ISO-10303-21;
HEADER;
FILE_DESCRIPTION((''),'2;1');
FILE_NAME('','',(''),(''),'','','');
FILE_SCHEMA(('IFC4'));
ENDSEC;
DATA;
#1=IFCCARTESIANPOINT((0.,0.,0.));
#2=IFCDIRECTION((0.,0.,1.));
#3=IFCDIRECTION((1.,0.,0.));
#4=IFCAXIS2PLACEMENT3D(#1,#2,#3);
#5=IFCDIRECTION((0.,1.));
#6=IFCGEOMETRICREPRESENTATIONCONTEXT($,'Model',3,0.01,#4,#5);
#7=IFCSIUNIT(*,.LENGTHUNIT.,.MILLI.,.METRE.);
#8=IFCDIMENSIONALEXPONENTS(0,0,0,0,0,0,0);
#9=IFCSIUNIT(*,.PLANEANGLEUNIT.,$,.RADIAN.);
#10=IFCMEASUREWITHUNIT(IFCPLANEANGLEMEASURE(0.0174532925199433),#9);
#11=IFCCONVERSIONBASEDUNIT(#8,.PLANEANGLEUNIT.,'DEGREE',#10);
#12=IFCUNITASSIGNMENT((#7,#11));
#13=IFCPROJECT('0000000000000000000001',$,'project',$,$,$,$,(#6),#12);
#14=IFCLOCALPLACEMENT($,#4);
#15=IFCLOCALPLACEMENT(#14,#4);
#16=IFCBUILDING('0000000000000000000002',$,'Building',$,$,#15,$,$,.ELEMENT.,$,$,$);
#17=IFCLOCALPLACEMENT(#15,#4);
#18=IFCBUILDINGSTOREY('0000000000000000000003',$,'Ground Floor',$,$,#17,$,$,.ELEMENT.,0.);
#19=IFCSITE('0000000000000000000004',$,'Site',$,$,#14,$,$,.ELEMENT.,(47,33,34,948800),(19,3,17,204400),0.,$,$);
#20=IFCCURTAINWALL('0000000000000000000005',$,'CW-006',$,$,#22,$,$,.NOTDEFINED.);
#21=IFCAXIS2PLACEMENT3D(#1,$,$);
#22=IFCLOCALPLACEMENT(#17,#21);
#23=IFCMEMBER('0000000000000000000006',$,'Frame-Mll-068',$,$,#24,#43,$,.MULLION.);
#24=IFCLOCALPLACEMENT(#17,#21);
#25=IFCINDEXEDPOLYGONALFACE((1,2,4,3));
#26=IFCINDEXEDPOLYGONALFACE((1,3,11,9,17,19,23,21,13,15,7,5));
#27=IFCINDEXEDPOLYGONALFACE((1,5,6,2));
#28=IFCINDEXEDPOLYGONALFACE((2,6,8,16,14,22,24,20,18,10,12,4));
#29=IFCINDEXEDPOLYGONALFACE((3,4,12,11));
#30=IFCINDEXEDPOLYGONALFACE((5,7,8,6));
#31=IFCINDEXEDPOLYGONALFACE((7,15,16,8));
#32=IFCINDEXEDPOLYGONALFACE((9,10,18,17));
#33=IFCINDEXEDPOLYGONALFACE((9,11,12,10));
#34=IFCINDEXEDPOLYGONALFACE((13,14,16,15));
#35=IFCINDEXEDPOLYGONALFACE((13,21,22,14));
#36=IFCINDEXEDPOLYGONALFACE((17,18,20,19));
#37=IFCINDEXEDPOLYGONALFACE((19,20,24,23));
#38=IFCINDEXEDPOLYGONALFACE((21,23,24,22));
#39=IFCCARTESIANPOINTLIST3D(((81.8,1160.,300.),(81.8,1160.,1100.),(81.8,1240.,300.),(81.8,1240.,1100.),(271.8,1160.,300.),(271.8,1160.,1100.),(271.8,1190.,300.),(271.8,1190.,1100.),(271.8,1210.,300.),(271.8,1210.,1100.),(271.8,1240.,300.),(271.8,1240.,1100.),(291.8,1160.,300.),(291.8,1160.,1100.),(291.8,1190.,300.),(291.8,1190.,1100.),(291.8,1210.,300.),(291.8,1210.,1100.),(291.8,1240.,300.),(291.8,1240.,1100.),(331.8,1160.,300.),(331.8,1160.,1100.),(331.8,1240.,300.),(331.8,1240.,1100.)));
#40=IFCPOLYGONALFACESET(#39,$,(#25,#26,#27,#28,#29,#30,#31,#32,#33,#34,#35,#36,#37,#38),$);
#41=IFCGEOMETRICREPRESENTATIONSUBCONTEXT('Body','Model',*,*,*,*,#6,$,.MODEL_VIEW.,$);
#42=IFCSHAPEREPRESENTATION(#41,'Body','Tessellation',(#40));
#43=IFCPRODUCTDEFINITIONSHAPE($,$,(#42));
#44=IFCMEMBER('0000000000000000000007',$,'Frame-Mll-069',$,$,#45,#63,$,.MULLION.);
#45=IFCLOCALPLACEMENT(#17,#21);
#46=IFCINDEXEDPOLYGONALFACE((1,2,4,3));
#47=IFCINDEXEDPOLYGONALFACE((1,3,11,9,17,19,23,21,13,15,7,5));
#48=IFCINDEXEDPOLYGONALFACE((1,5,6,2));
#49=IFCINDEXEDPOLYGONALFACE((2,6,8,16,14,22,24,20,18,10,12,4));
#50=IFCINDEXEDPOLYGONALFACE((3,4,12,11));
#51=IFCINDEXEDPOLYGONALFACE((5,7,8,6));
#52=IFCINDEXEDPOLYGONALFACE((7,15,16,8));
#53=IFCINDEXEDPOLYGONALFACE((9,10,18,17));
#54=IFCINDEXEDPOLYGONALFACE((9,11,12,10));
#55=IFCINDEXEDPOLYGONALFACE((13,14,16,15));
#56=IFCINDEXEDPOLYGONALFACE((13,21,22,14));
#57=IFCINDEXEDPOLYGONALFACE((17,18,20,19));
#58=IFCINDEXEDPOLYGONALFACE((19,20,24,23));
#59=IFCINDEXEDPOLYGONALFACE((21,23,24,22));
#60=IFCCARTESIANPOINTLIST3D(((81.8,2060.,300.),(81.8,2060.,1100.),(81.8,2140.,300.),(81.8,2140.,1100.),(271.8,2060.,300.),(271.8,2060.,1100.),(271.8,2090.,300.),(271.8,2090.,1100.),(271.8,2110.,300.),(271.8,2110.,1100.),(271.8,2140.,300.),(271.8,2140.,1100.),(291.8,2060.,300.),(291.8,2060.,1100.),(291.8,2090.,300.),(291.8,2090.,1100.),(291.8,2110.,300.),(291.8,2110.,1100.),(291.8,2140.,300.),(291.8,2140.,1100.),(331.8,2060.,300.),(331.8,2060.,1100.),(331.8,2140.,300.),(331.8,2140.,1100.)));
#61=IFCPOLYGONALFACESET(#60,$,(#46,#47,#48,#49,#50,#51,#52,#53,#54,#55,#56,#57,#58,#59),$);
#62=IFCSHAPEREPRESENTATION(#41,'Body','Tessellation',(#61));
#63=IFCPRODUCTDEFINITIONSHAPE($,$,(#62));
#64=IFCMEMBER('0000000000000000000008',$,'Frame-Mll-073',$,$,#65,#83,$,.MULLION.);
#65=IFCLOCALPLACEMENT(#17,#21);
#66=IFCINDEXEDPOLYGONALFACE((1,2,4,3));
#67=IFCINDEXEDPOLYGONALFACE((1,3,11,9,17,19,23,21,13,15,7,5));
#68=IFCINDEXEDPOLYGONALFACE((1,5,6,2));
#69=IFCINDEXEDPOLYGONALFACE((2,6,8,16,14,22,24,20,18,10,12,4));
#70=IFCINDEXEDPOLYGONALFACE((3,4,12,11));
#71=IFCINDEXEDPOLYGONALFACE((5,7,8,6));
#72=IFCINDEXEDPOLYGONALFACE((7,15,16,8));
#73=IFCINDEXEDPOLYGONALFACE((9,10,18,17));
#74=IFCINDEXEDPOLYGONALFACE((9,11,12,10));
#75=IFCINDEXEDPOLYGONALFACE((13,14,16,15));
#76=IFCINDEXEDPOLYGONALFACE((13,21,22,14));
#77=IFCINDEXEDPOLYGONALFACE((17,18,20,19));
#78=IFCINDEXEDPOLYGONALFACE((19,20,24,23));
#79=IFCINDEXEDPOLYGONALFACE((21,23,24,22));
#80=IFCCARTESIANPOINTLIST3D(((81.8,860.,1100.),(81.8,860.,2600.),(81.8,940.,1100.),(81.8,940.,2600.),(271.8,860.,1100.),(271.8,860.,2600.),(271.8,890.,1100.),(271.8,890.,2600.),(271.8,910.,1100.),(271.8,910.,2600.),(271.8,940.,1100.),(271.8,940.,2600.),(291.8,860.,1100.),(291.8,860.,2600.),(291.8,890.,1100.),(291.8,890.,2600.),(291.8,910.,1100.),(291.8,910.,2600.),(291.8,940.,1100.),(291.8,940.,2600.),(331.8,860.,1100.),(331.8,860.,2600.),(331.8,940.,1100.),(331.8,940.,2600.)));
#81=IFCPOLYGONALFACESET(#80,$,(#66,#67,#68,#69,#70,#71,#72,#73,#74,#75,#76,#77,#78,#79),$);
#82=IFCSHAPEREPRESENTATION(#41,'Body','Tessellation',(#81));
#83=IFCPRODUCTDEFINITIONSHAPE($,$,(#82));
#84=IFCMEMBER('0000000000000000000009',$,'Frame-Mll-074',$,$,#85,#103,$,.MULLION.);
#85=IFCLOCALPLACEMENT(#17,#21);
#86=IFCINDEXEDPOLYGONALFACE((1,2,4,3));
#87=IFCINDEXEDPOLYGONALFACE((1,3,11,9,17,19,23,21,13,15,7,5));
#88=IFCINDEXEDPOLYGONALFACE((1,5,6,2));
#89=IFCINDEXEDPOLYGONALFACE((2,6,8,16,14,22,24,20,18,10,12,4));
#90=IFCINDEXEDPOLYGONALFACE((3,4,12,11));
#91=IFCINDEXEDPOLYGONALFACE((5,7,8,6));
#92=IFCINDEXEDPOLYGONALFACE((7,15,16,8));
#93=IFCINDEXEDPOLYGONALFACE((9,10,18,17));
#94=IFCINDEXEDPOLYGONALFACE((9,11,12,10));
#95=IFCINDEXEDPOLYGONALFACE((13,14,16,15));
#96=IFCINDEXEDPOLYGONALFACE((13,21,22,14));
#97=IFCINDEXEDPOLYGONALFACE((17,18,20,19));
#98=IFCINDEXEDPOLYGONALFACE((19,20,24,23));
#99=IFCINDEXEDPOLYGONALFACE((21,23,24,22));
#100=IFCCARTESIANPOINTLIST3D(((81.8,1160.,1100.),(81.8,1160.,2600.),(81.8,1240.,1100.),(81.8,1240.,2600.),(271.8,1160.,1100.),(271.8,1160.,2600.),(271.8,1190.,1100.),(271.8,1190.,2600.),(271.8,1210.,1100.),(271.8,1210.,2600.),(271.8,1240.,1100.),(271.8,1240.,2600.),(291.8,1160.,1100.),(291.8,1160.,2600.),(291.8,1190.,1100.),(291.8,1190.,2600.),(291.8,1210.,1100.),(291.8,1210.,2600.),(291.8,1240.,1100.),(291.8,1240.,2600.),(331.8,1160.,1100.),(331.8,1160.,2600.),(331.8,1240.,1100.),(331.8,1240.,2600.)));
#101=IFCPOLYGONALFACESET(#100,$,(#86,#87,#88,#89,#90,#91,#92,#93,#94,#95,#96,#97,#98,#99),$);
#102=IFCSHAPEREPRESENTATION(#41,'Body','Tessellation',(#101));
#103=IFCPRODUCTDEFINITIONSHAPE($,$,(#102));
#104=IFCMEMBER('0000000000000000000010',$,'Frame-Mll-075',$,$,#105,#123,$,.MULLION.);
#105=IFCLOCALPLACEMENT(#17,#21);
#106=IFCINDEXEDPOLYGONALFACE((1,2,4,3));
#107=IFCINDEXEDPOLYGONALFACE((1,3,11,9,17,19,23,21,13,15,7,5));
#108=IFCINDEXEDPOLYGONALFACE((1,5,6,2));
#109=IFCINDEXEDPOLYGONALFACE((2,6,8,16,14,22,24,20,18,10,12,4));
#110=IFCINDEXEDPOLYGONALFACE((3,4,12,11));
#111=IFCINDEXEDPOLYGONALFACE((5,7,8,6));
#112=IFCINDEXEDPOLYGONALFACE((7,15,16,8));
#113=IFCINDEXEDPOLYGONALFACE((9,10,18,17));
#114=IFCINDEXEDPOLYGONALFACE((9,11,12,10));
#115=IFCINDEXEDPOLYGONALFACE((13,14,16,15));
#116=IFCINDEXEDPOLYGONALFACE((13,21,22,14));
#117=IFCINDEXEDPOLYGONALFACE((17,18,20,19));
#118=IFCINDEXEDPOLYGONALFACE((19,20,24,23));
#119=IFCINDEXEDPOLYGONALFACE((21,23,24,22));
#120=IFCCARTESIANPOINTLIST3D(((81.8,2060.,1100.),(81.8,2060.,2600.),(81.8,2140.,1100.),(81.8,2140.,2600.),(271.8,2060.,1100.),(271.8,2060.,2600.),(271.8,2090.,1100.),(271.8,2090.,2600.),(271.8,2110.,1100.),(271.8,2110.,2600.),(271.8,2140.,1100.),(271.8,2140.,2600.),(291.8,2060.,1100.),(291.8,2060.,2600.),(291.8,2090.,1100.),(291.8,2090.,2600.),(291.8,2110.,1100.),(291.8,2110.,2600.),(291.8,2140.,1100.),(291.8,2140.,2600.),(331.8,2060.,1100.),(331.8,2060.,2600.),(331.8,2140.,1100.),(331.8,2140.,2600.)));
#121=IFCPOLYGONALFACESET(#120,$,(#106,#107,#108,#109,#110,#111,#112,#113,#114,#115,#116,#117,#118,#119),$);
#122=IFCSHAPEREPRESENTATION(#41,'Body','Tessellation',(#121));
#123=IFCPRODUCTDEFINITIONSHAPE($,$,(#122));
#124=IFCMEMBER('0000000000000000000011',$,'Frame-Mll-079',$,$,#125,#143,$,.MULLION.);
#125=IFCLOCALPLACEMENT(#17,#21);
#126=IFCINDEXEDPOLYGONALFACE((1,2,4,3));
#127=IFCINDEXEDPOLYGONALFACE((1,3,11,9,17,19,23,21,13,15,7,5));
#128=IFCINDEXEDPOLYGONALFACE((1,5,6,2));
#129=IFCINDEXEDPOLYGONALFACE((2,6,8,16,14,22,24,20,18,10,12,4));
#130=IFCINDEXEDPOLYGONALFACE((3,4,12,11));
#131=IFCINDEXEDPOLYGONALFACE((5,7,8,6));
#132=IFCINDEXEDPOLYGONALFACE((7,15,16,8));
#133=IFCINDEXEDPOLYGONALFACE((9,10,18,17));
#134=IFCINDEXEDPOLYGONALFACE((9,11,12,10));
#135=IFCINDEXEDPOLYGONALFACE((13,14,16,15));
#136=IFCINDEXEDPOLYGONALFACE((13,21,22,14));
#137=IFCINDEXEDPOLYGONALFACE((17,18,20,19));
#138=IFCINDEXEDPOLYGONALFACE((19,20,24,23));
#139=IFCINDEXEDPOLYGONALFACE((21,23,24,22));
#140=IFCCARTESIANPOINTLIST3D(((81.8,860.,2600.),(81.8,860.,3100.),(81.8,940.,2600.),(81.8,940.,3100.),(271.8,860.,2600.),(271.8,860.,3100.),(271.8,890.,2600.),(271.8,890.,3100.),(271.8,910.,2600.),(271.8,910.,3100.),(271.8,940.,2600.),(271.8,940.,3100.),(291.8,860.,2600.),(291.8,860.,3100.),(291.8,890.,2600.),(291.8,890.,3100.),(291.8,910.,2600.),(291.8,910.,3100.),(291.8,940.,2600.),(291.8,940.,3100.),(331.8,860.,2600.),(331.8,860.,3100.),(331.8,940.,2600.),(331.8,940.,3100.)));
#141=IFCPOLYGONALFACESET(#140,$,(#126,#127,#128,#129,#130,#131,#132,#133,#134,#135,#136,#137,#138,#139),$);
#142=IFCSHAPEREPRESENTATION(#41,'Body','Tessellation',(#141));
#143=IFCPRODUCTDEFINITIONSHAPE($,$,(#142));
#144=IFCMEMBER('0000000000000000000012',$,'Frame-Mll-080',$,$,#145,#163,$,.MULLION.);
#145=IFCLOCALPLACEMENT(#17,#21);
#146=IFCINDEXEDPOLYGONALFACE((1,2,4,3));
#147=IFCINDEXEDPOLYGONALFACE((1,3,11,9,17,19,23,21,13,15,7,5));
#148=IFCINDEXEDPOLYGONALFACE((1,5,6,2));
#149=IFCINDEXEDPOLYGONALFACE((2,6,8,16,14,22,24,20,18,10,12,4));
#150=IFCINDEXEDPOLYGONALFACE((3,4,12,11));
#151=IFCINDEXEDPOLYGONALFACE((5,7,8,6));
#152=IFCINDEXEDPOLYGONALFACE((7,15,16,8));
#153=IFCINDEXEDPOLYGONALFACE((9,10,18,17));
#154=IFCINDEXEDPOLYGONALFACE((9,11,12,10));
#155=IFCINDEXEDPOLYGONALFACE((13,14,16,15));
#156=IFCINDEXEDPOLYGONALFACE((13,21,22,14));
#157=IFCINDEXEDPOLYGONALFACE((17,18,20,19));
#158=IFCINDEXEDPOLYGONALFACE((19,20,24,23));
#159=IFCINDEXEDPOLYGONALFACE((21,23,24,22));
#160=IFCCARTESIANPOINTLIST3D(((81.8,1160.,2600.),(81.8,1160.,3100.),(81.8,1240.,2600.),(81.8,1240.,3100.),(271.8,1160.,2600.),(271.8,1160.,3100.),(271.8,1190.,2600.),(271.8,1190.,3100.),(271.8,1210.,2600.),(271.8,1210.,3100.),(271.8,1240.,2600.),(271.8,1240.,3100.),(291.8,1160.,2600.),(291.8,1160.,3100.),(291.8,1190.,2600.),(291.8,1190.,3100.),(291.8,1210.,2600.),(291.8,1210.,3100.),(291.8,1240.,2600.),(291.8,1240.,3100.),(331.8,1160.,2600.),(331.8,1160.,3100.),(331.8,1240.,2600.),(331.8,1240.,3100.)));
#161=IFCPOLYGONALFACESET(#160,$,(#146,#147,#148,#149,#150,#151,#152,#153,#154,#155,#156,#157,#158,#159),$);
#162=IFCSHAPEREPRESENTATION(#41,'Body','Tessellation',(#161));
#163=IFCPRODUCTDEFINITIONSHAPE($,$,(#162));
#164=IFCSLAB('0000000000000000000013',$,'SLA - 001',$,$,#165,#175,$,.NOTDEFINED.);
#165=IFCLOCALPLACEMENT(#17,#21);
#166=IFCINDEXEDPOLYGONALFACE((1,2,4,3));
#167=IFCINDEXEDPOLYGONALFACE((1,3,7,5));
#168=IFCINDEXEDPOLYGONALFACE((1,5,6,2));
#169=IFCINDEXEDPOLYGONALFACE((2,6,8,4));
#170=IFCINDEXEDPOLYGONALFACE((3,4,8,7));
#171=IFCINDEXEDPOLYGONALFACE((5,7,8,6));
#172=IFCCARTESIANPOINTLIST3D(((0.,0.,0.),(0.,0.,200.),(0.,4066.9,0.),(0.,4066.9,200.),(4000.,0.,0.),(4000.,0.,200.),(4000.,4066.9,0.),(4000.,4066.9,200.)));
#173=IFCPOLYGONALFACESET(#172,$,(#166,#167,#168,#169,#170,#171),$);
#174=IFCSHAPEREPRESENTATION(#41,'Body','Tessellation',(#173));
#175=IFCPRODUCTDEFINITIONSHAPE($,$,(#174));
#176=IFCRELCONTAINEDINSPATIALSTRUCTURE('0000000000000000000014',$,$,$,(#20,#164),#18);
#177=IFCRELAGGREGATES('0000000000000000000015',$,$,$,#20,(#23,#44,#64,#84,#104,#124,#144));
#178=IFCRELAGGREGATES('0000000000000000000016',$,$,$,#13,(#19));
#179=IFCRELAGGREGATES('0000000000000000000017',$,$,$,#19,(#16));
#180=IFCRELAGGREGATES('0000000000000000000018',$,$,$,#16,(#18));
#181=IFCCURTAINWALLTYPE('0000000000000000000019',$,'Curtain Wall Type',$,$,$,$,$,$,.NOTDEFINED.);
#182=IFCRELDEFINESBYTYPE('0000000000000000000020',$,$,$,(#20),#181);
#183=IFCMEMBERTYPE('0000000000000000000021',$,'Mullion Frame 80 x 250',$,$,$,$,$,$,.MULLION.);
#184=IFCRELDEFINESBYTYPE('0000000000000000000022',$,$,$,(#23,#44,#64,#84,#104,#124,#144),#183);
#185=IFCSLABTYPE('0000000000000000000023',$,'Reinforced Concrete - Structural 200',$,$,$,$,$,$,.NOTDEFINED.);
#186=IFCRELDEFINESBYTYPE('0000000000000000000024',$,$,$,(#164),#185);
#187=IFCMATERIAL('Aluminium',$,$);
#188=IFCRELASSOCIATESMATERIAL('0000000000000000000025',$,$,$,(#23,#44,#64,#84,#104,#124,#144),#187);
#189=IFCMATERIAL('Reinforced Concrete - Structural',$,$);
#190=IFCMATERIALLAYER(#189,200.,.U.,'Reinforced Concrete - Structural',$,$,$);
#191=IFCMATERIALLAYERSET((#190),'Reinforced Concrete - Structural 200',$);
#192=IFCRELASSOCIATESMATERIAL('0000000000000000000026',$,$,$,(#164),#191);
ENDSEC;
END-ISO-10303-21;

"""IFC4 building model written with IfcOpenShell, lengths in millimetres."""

from ifc_helpers import new_model, entity, si_unit, converted_unit, direction, frame, origin_with_axes, place, context, subcontext, project, spatial, line, indexed_curve, outline, extrude, material, layer, layer_set, layer_usage, type_object, element, aggregate, save


model = new_model("IFC4")

# Units and contexts
model_context = context("Model", 3, precision=0.01, world=origin_with_axes(), true_north=direction((0.0, 1.0)))
body_context = subcontext(model_context, "Body", "Model", "MODEL_VIEW")
ifc_project = project(units=[si_unit("LENGTHUNIT", "METRE", prefix="MILLI"), converted_unit("PLANEANGLEUNIT", "DEGREE", entity("IfcPlaneAngleMeasure", 0.0174532925199433), si_unit("PLANEANGLEUNIT", "RADIAN"), dimensions=[0, 0, 0, 0, 0, 0, 0])], contexts=[model_context])

# Site, building, storey
site_placement = place(None, origin_with_axes())
site = spatial("IfcSite", under=ifc_project, at=site_placement, Name="Site", CompositionType="ELEMENT", RefLatitude=(47, 33, 34, 948800), RefLongitude=(19, 3, 17, 204400), RefElevation=0.0)
building_placement = place(site_placement, origin_with_axes())
building = spatial("IfcBuilding", under=site, at=building_placement, Name="Building", CompositionType="ELEMENT")
storey_placement = place(building_placement, origin_with_axes())
storey = spatial("IfcBuildingStorey", under=building, at=storey_placement, Name="Ground Floor", CompositionType="ELEMENT", Elevation=0.0)

# Curtain wall, members
curtain_wall_type = type_object("IfcCurtainWallType", Name="Curtain Wall Type", PredefinedType="NOTDEFINED")
curtain_wall_placement = place(storey_placement, frame((281.8, 450.0, 200.0), z_axis=(0.0, 0.0, 1.0), x_axis=(1.0, 0.0, 0.0)))
curtain_wall = element("IfcCurtainWall", 1, at=curtain_wall_placement, inside=storey, type_object=curtain_wall_type, Name="CW-006", PredefinedType="NOTDEFINED")
ifc_material_1 = material(Name="Aluminium")
member_type_1 = type_object("IfcMemberType", Name="Mullion Frame 80 x 250", PredefinedType="MULLION")
member_1_placement = place(curtain_wall_placement, frame((0.0, 750.0, 0.0), z_axis=(0.0, 0.0, 1.0), x_axis=(0.0, -1.0, 0.0)))
member_1 = element("IfcMember", 2, at=member_1_placement, type_object=member_type_1, material=ifc_material_1, Name="Frame-Mll-068", PredefinedType="MULLION", context=body_context, shape_type="SweptSolid", body=[
    extrude(outline(indexed_curve([(-10.0, -10.0), (-40.0, -10.0), (-40.0, -200.0), (40.0, -200.0), (40.0, -10.0), (10.0, -10.0), (10.0, 10.0), (40.0, 10.0), (40.0, 50.0), (-40.0, 50.0), (-40.0, 10.0), (-10.0, 10.0)], segments=[line(1, 2, 3, 4, 5, 6, 7, 8, 9, 10, 11, 12, 1)])), frame((0.0, 0.0, 100.0), z_axis=(0.0, 0.0, 1.0), x_axis=(1.0, 0.0, 0.0)), (0.0, 0.0, 1.0), 800.0),
])
member_2_placement = place(curtain_wall_placement, frame((0.0, 1650.0, 0.0), z_axis=(0.0, 0.0, 1.0), x_axis=(0.0, -1.0, 0.0)))
member_2 = element("IfcMember", 3, at=member_2_placement, type_object=member_type_1, material=ifc_material_1, Name="Frame-Mll-069", PredefinedType="MULLION", context=body_context, shape_type="SweptSolid", body=[
    extrude(outline(indexed_curve([(-10.0, -10.0), (-40.0, -10.0), (-40.0, -200.0), (40.0, -200.0), (40.0, -10.0), (10.0, -10.0), (10.0, 10.0), (40.0, 10.0), (40.0, 50.0), (-40.0, 50.0), (-40.0, 10.0), (-10.0, 10.0)], segments=[line(1, 2, 3, 4, 5, 6, 7, 8, 9, 10, 11, 12, 1)])), frame((0.0, 0.0, 100.0), z_axis=(0.0, 0.0, 1.0), x_axis=(1.0, 0.0, 0.0)), (0.0, 0.0, 1.0), 800.0),
])
member_3_placement = place(curtain_wall_placement, frame((0.0, 450.0, 900.0), z_axis=(0.0, 0.0, 1.0), x_axis=(0.0, -1.0, 0.0)))
member_3 = element("IfcMember", 4, at=member_3_placement, type_object=member_type_1, material=ifc_material_1, Name="Frame-Mll-073", PredefinedType="MULLION", context=body_context, shape_type="SweptSolid", body=[
    extrude(outline(indexed_curve([(-10.0, -10.0), (-40.0, -10.0), (-40.0, -200.0), (40.0, -200.0), (40.0, -10.0), (10.0, -10.0), (10.0, 10.0), (40.0, 10.0), (40.0, 50.0), (-40.0, 50.0), (-40.0, 10.0), (-10.0, 10.0)], segments=[line(1, 2, 3, 4, 5, 6, 7, 8, 9, 10, 11, 12, 1)])), origin_with_axes(), (0.0, 0.0, 1.0), 1500.0),
])
member_4_placement = place(curtain_wall_placement, frame((0.0, 750.0, 900.0), z_axis=(0.0, 0.0, 1.0), x_axis=(0.0, -1.0, 0.0)))
member_4 = element("IfcMember", 5, at=member_4_placement, type_object=member_type_1, material=ifc_material_1, Name="Frame-Mll-074", PredefinedType="MULLION", context=body_context, shape_type="SweptSolid", body=[
    extrude(outline(indexed_curve([(-10.0, -10.0), (-40.0, -10.0), (-40.0, -200.0), (40.0, -200.0), (40.0, -10.0), (10.0, -10.0), (10.0, 10.0), (40.0, 10.0), (40.0, 50.0), (-40.0, 50.0), (-40.0, 10.0), (-10.0, 10.0)], segments=[line(1, 2, 3, 4, 5, 6, 7, 8, 9, 10, 11, 12, 1)])), origin_with_axes(), (0.0, 0.0, 1.0), 1500.0),
])
member_5_placement = place(curtain_wall_placement, frame((0.0, 1650.0, 900.0), z_axis=(0.0, 0.0, 1.0), x_axis=(0.0, -1.0, 0.0)))
member_5 = element("IfcMember", 6, at=member_5_placement, type_object=member_type_1, material=ifc_material_1, Name="Frame-Mll-075", PredefinedType="MULLION", context=body_context, shape_type="SweptSolid", body=[
    extrude(outline(indexed_curve([(-10.0, -10.0), (-40.0, -10.0), (-40.0, -200.0), (40.0, -200.0), (40.0, -10.0), (10.0, -10.0), (10.0, 10.0), (40.0, 10.0), (40.0, 50.0), (-40.0, 50.0), (-40.0, 10.0), (-10.0, 10.0)], segments=[line(1, 2, 3, 4, 5, 6, 7, 8, 9, 10, 11, 12, 1)])), origin_with_axes(), (0.0, 0.0, 1.0), 1500.0),
])
member_6_placement = place(curtain_wall_placement, frame((0.0, 450.0, 2400.0), z_axis=(0.0, 0.0, 1.0), x_axis=(0.0, -1.0, 0.0)))
member_6 = element("IfcMember", 7, at=member_6_placement, type_object=member_type_1, material=ifc_material_1, Name="Frame-Mll-079", PredefinedType="MULLION", context=body_context, shape_type="SweptSolid", body=[
    extrude(outline(indexed_curve([(-10.0, -10.0), (-40.0, -10.0), (-40.0, -200.0), (40.0, -200.0), (40.0, -10.0), (10.0, -10.0), (10.0, 10.0), (40.0, 10.0), (40.0, 50.0), (-40.0, 50.0), (-40.0, 10.0), (-10.0, 10.0)], segments=[line(1, 2, 3, 4, 5, 6, 7, 8, 9, 10, 11, 12, 1)])), origin_with_axes(), (0.0, 0.0, 1.0), 500.0),
])
member_7_placement = place(curtain_wall_placement, frame((0.0, 750.0, 2400.0), z_axis=(0.0, 0.0, 1.0), x_axis=(0.0, -1.0, 0.0)))
member_7 = element("IfcMember", 8, at=member_7_placement, type_object=member_type_1, material=ifc_material_1, Name="Frame-Mll-080", PredefinedType="MULLION", context=body_context, shape_type="SweptSolid", body=[
    extrude(outline(indexed_curve([(-10.0, -10.0), (-40.0, -10.0), (-40.0, -200.0), (40.0, -200.0), (40.0, -10.0), (10.0, -10.0), (10.0, 10.0), (40.0, 10.0), (40.0, 50.0), (-40.0, 50.0), (-40.0, 10.0), (-10.0, 10.0)], segments=[line(1, 2, 3, 4, 5, 6, 7, 8, 9, 10, 11, 12, 1)])), origin_with_axes(), (0.0, 0.0, 1.0), 500.0),
])

# Slab
ifc_material_2 = material(Name="Reinforced Concrete - Structural")
ifc_layer_1 = layer(ifc_material_2, 200.0, ventilated="UNKNOWN", Name="Reinforced Concrete - Structural")
ifc_layer_set_1 = layer_set([ifc_layer_1], Name="Reinforced Concrete - Structural 200")
ifc_layer_usage_1 = layer_usage(ifc_layer_set_1, "AXIS3", "NEGATIVE", 200.0)
slab_type = type_object("IfcSlabType", Name="Reinforced Concrete - Structural 200", PredefinedType="NOTDEFINED")
slab_placement = place(storey_placement, origin_with_axes())
element("IfcSlab", 9, at=slab_placement, inside=storey, type_object=slab_type, material=ifc_layer_usage_1, Name="SLA - 001", PredefinedType="NOTDEFINED", context=body_context, shape_type="SweptSolid", body=[
    extrude(outline(indexed_curve([(0.0, 0.0), (4000.0, 0.0), (4000.0, 4066.9), (0.0, 4066.9)], segments=[line(1, 2, 3, 4, 1)])), origin_with_axes(), (0.0, 0.0, 1.0), 200.0),
])

aggregate(curtain_wall, [member_1, member_2, member_3, member_4, member_5, member_6, member_7])

save(model, "model.ifc")
